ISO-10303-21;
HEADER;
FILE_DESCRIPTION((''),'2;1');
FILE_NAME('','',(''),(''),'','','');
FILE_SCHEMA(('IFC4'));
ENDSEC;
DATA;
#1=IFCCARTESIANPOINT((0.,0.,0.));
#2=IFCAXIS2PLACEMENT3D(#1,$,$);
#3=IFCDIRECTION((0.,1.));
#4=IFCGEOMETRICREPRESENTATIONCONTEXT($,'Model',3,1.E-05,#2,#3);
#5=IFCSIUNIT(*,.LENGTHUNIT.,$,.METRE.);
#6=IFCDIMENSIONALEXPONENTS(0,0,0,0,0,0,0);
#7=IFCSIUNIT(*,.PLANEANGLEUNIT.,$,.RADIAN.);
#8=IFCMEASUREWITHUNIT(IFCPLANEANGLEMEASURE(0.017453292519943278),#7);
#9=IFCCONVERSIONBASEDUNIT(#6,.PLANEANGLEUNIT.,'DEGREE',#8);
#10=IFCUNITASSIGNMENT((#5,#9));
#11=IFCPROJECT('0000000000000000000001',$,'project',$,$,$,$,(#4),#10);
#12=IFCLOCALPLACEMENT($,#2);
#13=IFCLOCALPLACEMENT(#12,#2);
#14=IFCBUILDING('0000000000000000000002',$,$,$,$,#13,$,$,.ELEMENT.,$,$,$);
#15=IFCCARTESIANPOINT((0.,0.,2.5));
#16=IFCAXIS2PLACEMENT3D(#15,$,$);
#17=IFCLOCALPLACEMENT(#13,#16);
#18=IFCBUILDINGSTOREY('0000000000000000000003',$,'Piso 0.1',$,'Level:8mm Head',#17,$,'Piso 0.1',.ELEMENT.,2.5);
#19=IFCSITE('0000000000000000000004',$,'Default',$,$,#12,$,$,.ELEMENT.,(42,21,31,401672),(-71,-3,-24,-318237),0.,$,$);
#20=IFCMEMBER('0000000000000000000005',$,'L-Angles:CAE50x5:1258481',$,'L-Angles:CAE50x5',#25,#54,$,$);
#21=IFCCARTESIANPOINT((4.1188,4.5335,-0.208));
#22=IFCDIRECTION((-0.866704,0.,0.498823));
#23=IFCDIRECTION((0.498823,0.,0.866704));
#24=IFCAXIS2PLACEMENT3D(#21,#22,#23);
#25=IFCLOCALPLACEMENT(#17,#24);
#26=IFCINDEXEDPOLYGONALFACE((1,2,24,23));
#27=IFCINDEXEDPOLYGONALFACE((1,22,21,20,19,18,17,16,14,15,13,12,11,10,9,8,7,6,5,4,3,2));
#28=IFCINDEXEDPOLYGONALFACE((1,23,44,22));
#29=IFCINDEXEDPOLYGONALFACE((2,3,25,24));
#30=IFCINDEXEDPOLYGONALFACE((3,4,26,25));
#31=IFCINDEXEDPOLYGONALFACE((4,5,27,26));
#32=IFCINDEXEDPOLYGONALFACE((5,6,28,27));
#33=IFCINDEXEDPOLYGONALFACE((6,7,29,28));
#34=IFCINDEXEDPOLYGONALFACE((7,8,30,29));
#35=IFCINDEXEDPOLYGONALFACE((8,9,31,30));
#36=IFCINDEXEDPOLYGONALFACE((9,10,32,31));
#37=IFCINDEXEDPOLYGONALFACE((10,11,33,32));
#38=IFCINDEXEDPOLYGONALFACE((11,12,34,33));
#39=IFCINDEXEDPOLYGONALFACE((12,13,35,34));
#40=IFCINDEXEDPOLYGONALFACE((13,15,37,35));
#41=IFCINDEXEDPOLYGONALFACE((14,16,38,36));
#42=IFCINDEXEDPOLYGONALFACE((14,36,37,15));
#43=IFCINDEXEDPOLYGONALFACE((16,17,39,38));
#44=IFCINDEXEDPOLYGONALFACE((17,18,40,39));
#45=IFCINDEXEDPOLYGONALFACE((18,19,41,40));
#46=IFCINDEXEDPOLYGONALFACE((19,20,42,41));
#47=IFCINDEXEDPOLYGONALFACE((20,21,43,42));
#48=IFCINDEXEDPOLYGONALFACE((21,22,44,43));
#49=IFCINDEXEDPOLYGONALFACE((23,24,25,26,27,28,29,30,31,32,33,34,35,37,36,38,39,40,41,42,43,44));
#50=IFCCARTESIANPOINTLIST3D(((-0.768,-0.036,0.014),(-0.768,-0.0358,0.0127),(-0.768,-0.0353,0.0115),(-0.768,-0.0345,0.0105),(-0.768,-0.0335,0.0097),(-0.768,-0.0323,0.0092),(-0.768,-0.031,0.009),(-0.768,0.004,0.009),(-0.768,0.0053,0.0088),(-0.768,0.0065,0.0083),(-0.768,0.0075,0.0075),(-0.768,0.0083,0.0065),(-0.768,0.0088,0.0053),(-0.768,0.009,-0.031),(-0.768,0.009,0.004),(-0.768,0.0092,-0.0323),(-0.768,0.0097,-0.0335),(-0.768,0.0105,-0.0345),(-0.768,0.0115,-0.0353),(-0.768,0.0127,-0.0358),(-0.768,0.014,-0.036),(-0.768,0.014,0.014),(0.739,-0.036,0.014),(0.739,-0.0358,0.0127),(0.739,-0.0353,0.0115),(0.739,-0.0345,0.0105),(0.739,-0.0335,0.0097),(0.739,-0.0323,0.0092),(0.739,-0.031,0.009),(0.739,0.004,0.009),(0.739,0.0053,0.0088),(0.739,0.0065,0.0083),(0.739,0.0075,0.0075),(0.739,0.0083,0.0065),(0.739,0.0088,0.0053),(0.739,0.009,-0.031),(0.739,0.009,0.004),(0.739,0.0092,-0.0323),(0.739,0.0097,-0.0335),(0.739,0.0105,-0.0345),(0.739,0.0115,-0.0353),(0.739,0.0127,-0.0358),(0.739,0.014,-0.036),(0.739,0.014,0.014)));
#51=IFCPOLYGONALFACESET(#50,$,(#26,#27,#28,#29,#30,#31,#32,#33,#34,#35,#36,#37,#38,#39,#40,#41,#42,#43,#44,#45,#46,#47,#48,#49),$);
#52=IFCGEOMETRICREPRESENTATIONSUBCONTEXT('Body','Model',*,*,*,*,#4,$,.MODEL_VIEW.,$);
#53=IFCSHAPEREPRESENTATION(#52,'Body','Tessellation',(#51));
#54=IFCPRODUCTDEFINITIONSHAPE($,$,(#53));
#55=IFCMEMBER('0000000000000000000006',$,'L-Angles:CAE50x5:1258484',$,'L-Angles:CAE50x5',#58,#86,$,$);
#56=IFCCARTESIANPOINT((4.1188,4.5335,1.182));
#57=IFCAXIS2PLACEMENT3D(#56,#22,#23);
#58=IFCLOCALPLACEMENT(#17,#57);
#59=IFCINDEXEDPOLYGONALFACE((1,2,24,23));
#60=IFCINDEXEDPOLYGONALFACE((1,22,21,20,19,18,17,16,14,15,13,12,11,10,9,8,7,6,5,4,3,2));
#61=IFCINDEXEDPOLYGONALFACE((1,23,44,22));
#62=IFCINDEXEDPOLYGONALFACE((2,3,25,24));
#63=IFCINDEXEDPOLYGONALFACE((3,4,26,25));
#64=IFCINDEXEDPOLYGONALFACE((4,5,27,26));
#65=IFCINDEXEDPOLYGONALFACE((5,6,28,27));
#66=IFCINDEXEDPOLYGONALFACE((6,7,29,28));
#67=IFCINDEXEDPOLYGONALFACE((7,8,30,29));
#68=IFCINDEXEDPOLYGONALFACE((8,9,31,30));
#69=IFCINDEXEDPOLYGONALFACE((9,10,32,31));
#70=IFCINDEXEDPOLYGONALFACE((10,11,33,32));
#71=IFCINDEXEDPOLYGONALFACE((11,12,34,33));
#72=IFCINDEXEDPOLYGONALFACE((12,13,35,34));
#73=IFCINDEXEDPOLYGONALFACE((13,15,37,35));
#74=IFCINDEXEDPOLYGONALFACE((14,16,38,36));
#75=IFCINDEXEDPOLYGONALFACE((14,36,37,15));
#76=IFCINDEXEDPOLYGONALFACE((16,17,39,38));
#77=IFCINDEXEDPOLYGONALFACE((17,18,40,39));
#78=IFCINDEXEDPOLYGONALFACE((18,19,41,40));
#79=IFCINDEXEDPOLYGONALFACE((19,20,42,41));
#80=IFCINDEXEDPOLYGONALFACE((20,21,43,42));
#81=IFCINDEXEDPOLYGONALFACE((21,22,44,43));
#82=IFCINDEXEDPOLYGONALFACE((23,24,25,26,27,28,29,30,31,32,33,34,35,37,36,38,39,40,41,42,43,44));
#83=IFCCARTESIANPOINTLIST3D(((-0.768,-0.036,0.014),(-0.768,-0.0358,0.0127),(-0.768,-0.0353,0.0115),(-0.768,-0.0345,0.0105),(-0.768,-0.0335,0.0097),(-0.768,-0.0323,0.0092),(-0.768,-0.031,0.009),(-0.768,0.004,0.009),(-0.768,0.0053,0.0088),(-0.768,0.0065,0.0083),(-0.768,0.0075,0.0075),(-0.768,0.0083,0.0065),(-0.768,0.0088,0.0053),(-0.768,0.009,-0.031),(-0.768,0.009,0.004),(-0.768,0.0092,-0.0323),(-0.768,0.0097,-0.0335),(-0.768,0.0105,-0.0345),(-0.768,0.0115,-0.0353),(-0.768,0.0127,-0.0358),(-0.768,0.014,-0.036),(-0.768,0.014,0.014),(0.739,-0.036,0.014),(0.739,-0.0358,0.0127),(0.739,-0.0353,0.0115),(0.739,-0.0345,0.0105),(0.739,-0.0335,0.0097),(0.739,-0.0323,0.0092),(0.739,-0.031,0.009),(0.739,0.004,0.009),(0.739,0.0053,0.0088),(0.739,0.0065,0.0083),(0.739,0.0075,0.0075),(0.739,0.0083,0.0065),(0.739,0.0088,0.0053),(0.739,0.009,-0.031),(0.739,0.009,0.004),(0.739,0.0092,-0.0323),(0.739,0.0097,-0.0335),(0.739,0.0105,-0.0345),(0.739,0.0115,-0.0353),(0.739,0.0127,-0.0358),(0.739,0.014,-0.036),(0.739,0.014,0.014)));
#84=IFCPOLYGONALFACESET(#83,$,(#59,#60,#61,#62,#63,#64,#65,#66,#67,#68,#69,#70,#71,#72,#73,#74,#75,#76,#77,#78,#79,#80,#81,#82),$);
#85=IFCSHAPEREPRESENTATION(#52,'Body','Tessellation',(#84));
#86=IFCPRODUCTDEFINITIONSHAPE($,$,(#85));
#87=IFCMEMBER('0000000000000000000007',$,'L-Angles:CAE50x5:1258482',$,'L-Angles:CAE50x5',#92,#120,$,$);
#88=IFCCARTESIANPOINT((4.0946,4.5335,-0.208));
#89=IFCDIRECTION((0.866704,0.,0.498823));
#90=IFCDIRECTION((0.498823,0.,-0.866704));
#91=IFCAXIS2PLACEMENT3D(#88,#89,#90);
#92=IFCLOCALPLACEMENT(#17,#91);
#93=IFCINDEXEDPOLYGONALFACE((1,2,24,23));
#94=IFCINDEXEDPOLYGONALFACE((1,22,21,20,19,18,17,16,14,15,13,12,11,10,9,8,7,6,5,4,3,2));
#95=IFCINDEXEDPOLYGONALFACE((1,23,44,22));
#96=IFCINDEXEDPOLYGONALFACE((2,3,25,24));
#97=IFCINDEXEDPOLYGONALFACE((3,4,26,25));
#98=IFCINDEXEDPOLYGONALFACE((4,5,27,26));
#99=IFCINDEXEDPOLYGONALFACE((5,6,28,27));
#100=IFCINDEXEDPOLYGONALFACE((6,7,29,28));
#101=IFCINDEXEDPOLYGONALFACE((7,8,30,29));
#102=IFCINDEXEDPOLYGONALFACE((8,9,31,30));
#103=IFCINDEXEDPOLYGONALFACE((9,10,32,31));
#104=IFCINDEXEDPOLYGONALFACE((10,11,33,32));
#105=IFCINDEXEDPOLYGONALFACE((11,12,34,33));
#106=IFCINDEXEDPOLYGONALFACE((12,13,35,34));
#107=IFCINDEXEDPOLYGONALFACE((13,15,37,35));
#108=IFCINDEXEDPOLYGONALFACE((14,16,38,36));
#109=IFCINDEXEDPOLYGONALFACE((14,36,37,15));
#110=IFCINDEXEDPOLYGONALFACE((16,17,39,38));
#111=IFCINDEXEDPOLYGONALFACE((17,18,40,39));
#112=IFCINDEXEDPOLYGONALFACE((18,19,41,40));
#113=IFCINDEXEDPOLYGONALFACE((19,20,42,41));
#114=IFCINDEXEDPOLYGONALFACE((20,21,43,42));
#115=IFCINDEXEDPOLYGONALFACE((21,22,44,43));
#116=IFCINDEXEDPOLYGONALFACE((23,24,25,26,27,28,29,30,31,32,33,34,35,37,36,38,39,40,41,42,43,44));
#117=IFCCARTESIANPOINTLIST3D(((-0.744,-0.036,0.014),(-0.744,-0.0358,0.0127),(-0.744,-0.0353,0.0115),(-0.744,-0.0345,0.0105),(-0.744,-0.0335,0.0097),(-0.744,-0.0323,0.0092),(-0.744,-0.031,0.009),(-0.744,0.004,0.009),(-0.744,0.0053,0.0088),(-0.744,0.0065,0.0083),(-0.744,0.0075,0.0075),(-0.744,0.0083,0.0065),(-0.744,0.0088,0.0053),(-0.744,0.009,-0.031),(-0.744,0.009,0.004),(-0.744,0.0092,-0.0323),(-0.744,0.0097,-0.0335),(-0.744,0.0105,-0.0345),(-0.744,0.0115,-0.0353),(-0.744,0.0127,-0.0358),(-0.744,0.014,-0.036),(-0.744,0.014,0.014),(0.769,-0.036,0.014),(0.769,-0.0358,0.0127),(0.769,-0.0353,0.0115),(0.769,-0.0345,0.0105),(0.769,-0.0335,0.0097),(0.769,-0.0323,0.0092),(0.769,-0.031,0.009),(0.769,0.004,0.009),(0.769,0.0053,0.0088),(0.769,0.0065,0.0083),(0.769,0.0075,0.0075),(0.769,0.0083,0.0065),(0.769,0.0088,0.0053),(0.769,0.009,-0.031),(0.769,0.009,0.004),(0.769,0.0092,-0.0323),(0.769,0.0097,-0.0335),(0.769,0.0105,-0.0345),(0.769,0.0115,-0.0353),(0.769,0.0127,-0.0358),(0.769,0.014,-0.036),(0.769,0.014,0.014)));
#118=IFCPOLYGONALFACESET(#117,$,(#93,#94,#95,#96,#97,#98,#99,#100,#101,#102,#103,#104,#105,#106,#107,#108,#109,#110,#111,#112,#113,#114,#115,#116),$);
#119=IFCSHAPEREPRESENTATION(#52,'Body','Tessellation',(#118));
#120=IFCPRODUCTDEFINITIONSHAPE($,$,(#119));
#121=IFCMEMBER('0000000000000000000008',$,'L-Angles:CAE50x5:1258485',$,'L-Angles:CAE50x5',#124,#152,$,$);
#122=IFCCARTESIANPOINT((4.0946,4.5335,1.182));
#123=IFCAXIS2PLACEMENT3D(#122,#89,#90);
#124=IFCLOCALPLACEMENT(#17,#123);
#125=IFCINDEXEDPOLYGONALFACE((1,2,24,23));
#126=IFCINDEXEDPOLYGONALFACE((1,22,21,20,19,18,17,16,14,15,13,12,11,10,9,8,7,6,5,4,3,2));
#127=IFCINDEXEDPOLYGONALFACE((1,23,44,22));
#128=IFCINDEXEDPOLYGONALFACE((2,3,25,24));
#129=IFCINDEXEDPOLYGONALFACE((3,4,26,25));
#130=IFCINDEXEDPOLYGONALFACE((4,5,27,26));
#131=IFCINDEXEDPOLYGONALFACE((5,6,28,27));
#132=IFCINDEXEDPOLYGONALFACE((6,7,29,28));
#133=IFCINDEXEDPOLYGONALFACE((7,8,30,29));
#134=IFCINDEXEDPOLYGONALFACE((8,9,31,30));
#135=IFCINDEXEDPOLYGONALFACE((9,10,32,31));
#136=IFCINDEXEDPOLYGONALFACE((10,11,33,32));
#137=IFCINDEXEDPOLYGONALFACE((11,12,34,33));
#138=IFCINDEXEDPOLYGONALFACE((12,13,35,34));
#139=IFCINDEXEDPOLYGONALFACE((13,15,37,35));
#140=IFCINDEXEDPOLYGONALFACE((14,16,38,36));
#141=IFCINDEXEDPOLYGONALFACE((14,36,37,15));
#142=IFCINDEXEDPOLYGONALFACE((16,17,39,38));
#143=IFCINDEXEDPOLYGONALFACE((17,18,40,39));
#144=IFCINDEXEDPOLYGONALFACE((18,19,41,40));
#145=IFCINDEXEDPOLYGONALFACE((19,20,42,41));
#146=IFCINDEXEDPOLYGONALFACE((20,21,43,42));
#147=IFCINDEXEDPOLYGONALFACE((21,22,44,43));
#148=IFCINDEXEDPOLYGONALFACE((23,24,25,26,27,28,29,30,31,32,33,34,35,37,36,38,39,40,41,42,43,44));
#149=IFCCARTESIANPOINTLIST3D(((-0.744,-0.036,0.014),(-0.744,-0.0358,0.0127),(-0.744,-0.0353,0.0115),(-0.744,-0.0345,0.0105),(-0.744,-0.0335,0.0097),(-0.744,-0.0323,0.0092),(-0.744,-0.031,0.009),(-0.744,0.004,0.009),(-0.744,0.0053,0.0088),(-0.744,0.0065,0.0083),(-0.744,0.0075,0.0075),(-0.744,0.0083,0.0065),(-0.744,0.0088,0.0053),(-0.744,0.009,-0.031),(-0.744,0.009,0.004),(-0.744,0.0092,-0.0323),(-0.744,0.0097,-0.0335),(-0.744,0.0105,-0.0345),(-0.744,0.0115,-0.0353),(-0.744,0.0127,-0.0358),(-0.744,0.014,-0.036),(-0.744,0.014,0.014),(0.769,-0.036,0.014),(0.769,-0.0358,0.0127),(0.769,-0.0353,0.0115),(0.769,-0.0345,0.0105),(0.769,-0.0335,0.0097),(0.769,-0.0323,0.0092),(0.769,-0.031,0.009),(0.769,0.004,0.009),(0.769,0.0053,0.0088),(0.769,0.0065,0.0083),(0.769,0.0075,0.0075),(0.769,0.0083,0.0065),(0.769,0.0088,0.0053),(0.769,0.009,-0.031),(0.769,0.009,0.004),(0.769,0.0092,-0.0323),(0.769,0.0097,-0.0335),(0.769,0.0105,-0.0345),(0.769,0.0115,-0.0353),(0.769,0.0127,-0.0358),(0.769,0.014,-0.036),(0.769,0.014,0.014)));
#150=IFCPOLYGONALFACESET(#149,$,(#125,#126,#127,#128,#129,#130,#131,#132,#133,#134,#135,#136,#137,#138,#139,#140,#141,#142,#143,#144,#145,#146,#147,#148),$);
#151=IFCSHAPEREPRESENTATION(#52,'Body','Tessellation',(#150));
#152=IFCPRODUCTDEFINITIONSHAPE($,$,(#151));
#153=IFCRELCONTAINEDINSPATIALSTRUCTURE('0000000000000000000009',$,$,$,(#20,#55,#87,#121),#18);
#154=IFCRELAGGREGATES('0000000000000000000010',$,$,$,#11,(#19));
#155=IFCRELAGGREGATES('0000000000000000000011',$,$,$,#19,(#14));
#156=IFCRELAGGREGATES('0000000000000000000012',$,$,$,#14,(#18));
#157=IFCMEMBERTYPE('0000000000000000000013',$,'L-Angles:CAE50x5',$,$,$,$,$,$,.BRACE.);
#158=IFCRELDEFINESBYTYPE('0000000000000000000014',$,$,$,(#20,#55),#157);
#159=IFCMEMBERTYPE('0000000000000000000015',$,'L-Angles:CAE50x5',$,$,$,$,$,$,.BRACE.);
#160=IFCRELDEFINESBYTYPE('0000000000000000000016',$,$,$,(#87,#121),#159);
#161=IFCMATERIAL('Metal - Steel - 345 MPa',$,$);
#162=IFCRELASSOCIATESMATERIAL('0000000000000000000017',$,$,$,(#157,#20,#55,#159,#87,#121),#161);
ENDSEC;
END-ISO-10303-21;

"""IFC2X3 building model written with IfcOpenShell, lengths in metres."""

from ifc_helpers import new_model, entity, si_unit, converted_unit, direction, frame, frame_2d, origin, place, context, subcontext, project, spatial, polyline, circle_curve, parameter, trimmed, segment, composite_curve, outline, extrude, source, transform, mapped, material, type_object, type_shapes, element, save


model = new_model("IFC2X3")

# Units and contexts
model_context = context("Model", 3, precision=1e-05, world=origin(), true_north=direction((0.0, 1.0)))
body_context = subcontext(model_context, "Body", "Model", "MODEL_VIEW")
ifc_project = project(units=[si_unit("LENGTHUNIT", "METRE"), converted_unit("PLANEANGLEUNIT", "DEGREE", entity("IfcPlaneAngleMeasure", 0.017453292519943278), si_unit("PLANEANGLEUNIT", "RADIAN"), dimensions=[0, 0, 0, 0, 0, 0, 0])], contexts=[model_context])

# Site, building, storey
site_placement = place(None, origin())
site = spatial("IfcSite", under=ifc_project, at=site_placement, Name="Default", CompositionType="ELEMENT", RefLatitude=(42, 21, 31, 401672), RefLongitude=(-71, -3, -24, -318237), RefElevation=0.0)
building_placement = place(site_placement, origin())
building = spatial("IfcBuilding", under=site, at=building_placement, CompositionType="ELEMENT")
storey_placement = place(building_placement, frame((0.0, 0.0, 2.5)))
storey = spatial("IfcBuildingStorey", under=building, at=storey_placement, Name="Piso 0.1", ObjectType="Level:8mm Head", LongName="Piso 0.1", CompositionType="ELEMENT", Elevation=2.5)

# Members
ifc_material = material(Name="Metal - Steel - 345 MPa")
member_type_1 = type_object("IfcMemberType", Name="L-Angles:CAE50x5", PredefinedType="BRACE", material=ifc_material)
shared_shape_1 = source(origin(), body_context, "Body", "SweptSolid", [
    extrude(outline(composite_curve([segment(polyline([(-0.0164, -0.0164), (0.0336, -0.0164)]), True, "CONTINUOUS"), segment(trimmed(circle_curve(frame_2d((0.0286, -0.0164), x_axis=(1.0, 0.0)), 0.005), [parameter(0.0)], [parameter(90.0)], True, "PARAMETER"), True, "CONTINUOUS"), segment(polyline([(0.0286, -0.0114), (-0.0064, -0.0114)]), True, "CONTINUOUS"), segment(trimmed(circle_curve(frame_2d((-0.0064, -0.0064), x_axis=(1.0, 0.0)), 0.005), [parameter(180.0)], [parameter(270.0)], True, "PARAMETER"), False, "CONTINUOUS"), segment(polyline([(-0.0114, -0.0064), (-0.0114, 0.0286)]), True, "CONTINUOUS"), segment(trimmed(circle_curve(frame_2d((-0.0164, 0.0286), x_axis=(1.0, 0.0)), 0.005), [parameter(0.0)], [parameter(90.0)], True, "PARAMETER"), True, "CONTINUOUS"), segment(polyline([(-0.0164, 0.0336), (-0.0164, -0.0164)]), True, "CONTINUOUS")], self_intersect=False)), frame((-0.768, -0.0024, -0.0024), z_axis=(1.0, 0.0, 0.0), x_axis=(0.0, -1.0, 0.0)), (0.0, 0.0, 1.0), 1.507),
])
type_shapes(member_type_1, [shared_shape_1])
for number, where, z_axis, x_axis, name in (
    (1, (4.1188, 4.5335, -0.208), (-0.866704, 0.0, 0.498823), (0.498823, 0.0, 0.866704), "L-Angles:CAE50x5:1258481"),
    (2, (4.1188, 4.5335, 1.182), (-0.866704, 0.0, 0.498823), (0.498823, 0.0, 0.866704), "L-Angles:CAE50x5:1258484"),
):
    element("IfcMember", number, at=place(storey_placement, frame(where, z_axis=z_axis, x_axis=x_axis)), inside=storey, type_object=member_type_1, material=ifc_material, Name=name, ObjectType="L-Angles:CAE50x5", context=body_context, shape_type="MappedRepresentation", body=[
        mapped(shared_shape_1, transform((0.0, 0.0, 0.0), scale=1.0)),
    ])
member_type_2 = type_object("IfcMemberType", Name="L-Angles:CAE50x5", PredefinedType="BRACE", material=ifc_material)
shared_shape_2 = source(origin(), body_context, "Body", "SweptSolid", [
    extrude(outline(composite_curve([segment(polyline([(-0.0164, -0.0164), (0.0336, -0.0164)]), True, "CONTINUOUS"), segment(trimmed(circle_curve(frame_2d((0.0286, -0.0164), x_axis=(1.0, 0.0)), 0.005), [parameter(0.0)], [parameter(90.0)], True, "PARAMETER"), True, "CONTINUOUS"), segment(polyline([(0.0286, -0.0114), (-0.0064, -0.0114)]), True, "CONTINUOUS"), segment(trimmed(circle_curve(frame_2d((-0.0064, -0.0064), x_axis=(1.0, 0.0)), 0.005), [parameter(180.0)], [parameter(270.0)], True, "PARAMETER"), False, "CONTINUOUS"), segment(polyline([(-0.0114, -0.0064), (-0.0114, 0.0286)]), True, "CONTINUOUS"), segment(trimmed(circle_curve(frame_2d((-0.0164, 0.0286), x_axis=(1.0, 0.0)), 0.005), [parameter(0.0)], [parameter(90.0)], True, "PARAMETER"), True, "CONTINUOUS"), segment(polyline([(-0.0164, 0.0336), (-0.0164, -0.0164)]), True, "CONTINUOUS")], self_intersect=False)), frame((-0.744, -0.0024, -0.0024), z_axis=(1.0, 0.0, 0.0), x_axis=(0.0, -1.0, 0.0)), (0.0, 0.0, 1.0), 1.513),
])
type_shapes(member_type_2, [shared_shape_2])
for number, where, z_axis, x_axis, name in (
    (3, (4.0946, 4.5335, -0.208), (0.866704, 0.0, 0.498823), (0.498823, 0.0, -0.866704), "L-Angles:CAE50x5:1258482"),
    (4, (4.0946, 4.5335, 1.182), (0.866704, 0.0, 0.498823), (0.498823, 0.0, -0.866704), "L-Angles:CAE50x5:1258485"),
):
    element("IfcMember", number, at=place(storey_placement, frame(where, z_axis=z_axis, x_axis=x_axis)), inside=storey, type_object=member_type_2, material=ifc_material, Name=name, ObjectType="L-Angles:CAE50x5", context=body_context, shape_type="MappedRepresentation", body=[
        mapped(shared_shape_2, transform((0.0, 0.0, 0.0), scale=1.0)),
    ])

save(model, "model.ifc")
